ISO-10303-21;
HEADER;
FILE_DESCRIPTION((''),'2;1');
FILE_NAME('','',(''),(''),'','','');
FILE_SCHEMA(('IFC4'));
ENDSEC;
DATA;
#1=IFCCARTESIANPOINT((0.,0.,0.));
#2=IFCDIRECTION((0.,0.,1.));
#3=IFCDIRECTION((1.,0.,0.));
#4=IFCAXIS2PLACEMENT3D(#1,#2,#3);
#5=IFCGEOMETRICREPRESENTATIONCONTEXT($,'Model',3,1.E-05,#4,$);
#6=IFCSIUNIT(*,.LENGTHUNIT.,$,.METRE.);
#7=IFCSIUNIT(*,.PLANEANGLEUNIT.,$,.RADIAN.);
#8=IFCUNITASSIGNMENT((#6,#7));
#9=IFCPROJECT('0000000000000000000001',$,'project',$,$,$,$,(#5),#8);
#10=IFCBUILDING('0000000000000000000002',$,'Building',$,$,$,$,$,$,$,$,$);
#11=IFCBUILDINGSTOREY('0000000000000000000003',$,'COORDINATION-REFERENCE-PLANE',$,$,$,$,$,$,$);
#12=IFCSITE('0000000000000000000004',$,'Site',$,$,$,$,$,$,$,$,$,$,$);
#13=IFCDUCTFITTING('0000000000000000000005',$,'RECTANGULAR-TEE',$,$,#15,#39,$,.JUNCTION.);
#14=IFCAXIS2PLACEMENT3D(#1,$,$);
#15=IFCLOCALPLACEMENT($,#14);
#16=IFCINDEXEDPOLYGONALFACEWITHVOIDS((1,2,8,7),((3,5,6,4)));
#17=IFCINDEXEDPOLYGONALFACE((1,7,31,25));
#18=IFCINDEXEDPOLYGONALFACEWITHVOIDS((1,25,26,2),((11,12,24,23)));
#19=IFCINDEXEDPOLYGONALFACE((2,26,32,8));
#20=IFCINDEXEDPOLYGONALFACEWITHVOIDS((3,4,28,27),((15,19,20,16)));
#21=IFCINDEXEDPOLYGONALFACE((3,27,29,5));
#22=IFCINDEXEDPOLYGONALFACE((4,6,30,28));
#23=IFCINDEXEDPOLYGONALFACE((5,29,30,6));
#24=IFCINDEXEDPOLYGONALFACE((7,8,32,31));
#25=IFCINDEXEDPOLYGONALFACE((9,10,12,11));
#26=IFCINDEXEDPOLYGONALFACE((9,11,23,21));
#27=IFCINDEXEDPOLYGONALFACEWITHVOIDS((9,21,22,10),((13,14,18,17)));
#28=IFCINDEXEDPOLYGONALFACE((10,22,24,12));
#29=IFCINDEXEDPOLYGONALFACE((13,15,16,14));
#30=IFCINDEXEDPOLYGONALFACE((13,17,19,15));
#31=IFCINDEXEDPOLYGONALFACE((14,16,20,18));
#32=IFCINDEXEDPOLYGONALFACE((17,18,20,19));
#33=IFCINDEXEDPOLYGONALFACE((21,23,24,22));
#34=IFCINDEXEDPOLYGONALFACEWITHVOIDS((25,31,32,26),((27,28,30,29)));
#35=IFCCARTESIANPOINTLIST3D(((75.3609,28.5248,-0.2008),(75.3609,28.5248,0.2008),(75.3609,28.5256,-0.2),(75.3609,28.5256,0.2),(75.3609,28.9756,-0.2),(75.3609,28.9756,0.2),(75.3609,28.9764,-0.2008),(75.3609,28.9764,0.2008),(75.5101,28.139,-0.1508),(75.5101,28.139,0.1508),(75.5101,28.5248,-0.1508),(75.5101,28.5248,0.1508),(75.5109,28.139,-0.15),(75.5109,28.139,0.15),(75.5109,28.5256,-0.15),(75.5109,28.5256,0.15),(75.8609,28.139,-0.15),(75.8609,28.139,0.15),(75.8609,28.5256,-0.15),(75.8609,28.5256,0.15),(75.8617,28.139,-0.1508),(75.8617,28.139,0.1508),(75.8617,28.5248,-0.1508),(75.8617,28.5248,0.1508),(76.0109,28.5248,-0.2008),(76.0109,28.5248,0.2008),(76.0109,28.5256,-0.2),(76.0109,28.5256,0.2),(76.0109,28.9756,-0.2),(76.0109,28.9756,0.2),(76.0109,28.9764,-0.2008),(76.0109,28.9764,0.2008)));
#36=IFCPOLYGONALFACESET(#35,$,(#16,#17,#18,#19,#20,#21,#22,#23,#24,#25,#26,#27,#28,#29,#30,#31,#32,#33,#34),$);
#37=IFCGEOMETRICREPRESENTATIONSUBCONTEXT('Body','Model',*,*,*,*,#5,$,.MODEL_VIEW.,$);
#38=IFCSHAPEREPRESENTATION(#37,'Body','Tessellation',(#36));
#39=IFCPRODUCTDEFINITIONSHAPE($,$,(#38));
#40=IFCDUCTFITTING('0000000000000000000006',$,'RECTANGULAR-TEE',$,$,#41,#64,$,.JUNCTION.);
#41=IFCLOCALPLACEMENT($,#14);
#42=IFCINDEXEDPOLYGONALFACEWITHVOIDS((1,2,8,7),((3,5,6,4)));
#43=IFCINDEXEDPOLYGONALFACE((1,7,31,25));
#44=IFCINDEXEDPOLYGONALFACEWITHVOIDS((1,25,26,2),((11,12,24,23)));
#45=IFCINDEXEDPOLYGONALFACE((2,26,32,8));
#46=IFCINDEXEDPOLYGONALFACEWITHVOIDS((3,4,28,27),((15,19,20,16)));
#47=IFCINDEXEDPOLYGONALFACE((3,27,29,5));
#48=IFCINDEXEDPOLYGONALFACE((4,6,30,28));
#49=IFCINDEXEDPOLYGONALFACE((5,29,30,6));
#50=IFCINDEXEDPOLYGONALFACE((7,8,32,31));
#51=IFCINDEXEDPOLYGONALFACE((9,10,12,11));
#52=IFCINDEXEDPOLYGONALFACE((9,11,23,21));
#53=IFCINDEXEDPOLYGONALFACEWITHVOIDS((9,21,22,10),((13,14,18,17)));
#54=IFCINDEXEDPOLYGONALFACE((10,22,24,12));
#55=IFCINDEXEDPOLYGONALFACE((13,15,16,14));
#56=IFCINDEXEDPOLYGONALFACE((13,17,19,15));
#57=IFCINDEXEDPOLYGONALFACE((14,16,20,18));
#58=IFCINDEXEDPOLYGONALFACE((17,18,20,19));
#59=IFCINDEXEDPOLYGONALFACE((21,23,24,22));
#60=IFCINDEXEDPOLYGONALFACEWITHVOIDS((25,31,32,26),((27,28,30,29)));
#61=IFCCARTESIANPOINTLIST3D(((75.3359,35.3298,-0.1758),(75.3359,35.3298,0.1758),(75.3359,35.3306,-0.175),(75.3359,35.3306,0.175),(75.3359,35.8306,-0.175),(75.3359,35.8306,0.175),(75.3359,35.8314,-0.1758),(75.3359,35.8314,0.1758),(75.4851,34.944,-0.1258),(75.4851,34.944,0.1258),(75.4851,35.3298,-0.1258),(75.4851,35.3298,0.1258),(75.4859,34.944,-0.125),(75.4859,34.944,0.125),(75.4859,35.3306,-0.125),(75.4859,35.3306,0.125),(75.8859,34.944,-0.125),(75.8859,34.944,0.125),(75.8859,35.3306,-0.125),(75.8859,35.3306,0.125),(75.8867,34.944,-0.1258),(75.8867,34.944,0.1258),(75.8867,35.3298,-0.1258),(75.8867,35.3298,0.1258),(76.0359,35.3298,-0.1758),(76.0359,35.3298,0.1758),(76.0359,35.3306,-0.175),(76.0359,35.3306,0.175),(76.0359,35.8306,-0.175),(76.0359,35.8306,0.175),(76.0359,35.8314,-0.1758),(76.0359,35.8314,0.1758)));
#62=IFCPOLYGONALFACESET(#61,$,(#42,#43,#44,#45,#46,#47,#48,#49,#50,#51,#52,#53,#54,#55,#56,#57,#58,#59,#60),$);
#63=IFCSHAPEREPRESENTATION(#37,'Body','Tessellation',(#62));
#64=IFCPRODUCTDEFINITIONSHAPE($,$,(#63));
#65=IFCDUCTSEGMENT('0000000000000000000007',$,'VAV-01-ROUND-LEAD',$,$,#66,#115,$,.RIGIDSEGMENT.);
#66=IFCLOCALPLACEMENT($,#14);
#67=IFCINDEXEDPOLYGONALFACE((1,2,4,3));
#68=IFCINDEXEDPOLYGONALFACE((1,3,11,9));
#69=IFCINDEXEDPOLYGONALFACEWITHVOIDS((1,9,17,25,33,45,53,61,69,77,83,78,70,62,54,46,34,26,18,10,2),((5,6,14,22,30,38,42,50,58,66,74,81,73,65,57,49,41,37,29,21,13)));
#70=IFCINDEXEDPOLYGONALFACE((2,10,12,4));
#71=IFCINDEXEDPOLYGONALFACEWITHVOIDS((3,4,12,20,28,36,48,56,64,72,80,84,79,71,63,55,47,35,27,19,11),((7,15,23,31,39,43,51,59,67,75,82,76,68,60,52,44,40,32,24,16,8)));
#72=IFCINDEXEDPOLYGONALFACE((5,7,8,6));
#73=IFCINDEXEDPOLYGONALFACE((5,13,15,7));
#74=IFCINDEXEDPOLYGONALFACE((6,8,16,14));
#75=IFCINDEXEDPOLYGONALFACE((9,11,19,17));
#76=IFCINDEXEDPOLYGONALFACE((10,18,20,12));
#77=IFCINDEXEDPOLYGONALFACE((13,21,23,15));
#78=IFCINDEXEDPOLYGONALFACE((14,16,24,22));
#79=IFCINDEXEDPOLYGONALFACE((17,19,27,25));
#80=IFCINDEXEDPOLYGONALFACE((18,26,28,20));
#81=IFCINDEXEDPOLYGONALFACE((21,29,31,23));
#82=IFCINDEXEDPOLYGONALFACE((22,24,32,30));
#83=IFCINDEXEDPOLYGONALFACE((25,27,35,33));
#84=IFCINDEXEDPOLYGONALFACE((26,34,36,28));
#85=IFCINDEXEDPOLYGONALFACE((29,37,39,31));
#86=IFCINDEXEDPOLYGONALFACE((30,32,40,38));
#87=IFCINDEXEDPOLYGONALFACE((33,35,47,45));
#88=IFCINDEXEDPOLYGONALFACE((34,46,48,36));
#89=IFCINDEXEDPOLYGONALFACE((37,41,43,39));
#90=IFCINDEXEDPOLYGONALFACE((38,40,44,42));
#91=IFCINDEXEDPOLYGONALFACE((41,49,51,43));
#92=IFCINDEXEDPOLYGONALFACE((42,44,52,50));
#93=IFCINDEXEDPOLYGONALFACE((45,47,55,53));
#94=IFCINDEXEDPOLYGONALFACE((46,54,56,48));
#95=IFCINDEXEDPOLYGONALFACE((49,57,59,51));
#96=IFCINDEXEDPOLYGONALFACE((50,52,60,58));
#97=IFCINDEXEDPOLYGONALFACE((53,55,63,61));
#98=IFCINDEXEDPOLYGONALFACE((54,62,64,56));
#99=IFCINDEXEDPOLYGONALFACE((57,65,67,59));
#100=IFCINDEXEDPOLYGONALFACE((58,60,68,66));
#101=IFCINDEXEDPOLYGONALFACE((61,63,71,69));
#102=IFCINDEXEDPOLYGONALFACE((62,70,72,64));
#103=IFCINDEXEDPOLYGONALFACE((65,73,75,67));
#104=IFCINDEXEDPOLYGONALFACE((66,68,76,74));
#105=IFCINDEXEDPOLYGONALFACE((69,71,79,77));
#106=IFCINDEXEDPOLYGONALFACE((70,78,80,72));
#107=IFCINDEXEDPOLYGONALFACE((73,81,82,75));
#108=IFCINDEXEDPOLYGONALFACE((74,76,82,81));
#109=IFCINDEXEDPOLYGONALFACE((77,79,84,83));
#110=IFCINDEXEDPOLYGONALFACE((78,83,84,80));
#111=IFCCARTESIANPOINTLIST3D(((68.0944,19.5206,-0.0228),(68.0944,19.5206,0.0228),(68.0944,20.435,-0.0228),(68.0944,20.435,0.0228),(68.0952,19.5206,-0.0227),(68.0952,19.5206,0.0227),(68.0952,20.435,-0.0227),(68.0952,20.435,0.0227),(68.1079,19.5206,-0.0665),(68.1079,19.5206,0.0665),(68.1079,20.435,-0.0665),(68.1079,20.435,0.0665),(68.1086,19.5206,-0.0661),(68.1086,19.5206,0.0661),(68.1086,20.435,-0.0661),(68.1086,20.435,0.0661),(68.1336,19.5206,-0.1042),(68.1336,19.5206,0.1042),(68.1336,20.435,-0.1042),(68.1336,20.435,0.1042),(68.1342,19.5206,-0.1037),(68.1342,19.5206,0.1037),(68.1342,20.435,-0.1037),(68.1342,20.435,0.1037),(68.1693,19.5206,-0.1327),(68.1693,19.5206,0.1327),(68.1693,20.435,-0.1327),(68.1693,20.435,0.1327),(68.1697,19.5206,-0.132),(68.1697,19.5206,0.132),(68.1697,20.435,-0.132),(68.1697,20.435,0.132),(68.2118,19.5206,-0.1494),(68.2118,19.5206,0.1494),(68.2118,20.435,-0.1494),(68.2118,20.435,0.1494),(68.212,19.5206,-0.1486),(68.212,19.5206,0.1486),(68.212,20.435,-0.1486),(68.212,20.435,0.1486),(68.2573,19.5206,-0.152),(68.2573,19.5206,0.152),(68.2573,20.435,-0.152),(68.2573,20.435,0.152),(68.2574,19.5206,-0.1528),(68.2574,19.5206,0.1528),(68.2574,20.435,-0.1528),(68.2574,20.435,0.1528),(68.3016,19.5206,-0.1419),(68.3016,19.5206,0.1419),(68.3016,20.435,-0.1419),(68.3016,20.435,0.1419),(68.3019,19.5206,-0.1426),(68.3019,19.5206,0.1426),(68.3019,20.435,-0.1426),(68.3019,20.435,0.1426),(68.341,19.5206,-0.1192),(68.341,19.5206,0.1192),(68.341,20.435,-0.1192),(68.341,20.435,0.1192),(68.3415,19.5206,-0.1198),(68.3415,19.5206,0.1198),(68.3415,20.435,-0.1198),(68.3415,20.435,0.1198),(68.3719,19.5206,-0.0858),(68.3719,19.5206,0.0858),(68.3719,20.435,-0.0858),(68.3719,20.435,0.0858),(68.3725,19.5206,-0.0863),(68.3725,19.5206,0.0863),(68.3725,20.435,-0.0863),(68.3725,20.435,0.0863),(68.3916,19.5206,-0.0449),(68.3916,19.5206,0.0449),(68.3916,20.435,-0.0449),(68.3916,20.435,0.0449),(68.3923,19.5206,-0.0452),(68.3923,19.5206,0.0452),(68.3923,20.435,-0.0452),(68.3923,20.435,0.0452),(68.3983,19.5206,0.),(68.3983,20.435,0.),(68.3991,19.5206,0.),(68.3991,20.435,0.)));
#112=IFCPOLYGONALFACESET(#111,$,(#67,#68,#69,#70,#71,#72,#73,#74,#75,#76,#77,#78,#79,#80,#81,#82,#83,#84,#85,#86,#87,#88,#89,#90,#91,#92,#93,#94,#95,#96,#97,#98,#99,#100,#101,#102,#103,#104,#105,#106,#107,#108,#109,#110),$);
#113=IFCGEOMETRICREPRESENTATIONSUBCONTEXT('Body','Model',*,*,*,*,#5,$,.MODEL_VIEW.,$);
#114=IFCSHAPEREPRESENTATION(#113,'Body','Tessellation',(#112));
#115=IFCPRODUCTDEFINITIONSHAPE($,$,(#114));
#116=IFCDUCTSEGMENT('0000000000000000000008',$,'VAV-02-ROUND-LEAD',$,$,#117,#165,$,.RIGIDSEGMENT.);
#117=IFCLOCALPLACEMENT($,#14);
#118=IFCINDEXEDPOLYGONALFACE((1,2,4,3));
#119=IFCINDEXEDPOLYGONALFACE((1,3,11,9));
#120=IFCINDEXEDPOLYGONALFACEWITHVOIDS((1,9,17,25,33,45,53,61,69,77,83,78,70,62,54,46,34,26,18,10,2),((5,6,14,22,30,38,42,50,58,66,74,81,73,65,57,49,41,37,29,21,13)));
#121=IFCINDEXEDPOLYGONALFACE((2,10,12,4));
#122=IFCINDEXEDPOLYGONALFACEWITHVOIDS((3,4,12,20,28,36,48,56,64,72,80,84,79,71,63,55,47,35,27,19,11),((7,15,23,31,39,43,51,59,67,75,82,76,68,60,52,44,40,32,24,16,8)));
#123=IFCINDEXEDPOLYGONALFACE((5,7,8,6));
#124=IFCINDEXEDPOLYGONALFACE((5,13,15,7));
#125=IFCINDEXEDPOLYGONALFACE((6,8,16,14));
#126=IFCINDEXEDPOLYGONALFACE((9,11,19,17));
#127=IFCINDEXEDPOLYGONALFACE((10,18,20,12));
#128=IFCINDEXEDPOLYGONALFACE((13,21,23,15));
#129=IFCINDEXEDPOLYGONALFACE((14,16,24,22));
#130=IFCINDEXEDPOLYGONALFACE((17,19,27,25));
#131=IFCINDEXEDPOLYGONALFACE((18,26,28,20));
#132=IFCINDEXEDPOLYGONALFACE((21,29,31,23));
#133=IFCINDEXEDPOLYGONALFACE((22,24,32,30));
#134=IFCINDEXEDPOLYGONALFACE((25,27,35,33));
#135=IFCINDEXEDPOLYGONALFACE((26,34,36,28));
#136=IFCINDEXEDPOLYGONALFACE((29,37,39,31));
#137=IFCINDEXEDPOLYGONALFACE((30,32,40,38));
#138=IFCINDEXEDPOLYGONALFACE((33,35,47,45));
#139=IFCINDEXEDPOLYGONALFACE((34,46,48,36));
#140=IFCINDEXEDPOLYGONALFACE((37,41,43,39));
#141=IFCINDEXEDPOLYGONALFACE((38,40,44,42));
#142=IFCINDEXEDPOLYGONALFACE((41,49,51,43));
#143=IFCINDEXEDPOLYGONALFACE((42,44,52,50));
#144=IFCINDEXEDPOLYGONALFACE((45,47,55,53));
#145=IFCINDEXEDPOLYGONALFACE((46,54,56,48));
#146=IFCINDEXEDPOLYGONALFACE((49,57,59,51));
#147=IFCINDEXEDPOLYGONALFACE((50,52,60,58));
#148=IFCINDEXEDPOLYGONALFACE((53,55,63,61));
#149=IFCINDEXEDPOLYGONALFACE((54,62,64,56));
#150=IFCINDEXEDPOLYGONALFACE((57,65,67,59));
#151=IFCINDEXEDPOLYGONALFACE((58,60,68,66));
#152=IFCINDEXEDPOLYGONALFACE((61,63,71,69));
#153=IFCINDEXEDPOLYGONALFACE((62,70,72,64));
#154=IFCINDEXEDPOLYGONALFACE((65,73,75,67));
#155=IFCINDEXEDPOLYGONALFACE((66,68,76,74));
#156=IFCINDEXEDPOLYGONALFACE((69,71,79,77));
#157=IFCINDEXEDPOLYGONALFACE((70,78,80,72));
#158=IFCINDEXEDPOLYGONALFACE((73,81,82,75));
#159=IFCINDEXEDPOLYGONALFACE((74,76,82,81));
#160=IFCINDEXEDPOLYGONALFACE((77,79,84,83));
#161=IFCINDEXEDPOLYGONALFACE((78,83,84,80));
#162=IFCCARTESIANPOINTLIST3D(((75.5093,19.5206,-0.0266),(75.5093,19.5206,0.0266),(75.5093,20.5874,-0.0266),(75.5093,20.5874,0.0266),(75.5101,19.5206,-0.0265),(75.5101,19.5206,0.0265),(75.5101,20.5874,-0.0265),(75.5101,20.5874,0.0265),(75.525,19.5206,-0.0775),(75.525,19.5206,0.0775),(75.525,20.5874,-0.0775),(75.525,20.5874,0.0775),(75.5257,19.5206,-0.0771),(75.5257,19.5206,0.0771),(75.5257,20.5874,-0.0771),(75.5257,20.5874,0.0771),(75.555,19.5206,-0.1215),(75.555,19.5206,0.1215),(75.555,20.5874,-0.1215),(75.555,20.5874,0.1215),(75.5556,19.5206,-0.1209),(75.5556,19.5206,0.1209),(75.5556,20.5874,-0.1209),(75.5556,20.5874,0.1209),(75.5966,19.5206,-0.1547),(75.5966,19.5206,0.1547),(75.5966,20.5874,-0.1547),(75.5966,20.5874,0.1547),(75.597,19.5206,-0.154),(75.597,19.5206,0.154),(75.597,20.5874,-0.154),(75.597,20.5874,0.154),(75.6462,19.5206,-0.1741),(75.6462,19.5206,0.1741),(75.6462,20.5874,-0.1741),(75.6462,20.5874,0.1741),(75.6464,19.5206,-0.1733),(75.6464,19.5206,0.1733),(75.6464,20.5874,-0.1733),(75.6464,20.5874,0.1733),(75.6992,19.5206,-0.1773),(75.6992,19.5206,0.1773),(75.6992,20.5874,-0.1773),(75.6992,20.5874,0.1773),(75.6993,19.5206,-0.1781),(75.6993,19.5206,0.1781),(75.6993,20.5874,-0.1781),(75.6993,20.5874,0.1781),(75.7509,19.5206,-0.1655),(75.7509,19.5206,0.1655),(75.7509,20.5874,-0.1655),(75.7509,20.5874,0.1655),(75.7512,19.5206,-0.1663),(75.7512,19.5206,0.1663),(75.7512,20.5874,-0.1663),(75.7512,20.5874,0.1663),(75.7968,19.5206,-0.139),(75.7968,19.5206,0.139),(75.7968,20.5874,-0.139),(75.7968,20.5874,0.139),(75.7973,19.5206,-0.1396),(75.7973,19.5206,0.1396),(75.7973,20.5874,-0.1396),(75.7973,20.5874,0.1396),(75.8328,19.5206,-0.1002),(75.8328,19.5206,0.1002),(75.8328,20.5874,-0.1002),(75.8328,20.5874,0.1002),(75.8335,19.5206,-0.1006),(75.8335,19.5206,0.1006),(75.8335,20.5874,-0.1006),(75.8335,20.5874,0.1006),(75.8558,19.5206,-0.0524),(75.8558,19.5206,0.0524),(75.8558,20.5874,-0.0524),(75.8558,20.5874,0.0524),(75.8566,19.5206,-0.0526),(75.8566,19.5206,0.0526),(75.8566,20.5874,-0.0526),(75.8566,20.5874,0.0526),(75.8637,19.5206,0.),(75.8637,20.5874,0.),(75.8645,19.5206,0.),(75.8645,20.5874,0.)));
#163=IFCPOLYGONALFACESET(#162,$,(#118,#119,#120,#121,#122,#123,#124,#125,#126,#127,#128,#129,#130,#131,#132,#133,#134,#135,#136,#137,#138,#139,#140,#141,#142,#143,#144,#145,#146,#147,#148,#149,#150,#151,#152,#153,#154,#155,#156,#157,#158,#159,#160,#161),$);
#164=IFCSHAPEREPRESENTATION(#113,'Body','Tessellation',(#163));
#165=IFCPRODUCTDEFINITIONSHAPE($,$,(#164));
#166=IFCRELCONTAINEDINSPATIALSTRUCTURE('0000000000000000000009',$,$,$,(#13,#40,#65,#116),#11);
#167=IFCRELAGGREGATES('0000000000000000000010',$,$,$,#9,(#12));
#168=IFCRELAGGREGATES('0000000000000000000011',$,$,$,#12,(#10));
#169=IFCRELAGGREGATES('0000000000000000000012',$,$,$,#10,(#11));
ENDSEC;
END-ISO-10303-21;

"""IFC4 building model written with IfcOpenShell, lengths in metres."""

from ifc_helpers import new_model, si_unit, frame, origin, origin_with_axes, place, context, subcontext, project, spatial, rectangle, hollow_circle, extrude, boolean, element, save


model = new_model("IFC4")

# Units and contexts
model_context = context("Model", 3, precision=1e-05, world=origin_with_axes())
body_context_1 = subcontext(model_context, "Body", "Model", "MODEL_VIEW")
body_context_2 = subcontext(model_context, "Body", "Model", "MODEL_VIEW")
ifc_project = project(units=[si_unit("LENGTHUNIT", "METRE"), si_unit("PLANEANGLEUNIT", "RADIAN")], contexts=[model_context])

# Site, building, storey
site = spatial("IfcSite", under=ifc_project, Name="Site")
building = spatial("IfcBuilding", under=site, Name="Building")
storey = spatial("IfcBuildingStorey", under=building, Name="COORDINATION-REFERENCE-PLANE")

# Duct fittings
duct_fitting_1_placement = place(None, frame((75.6859, 28.7506, 0.0), z_axis=(-1.0, 0.0, 0.0), x_axis=(0.0, -1.0, 0.0)))
solid_1 = boolean("UNION", extrude(rectangle(XDim=0.45, YDim=0.4), frame((0.0, 0.0, -0.325), z_axis=(0.0, 0.0, 1.0), x_axis=(1.0, 0.0, 0.0)), (0.0, 0.0, 1.0), 0.65), extrude(rectangle(XDim=0.35, YDim=0.3), frame((0.0, 0.0, 0.0), z_axis=(1.0, 0.0, 0.0), x_axis=(0.0, 0.0, -1.0)), (0.0, 0.0, 1.0), 0.6116))
element("IfcDuctFitting", 1, at=duct_fitting_1_placement, inside=storey, Name="RECTANGULAR-TEE", PredefinedType="JUNCTION", context=body_context_1, shape_type="CSG", body=[
    boolean("DIFFERENCE", boolean("UNION", extrude(rectangle(XDim=0.4516, YDim=0.4016), frame((0.0, 0.0, -0.325), z_axis=(0.0, 0.0, 1.0), x_axis=(1.0, 0.0, 0.0)), (0.0, 0.0, 1.0), 0.65), extrude(rectangle(XDim=0.3516, YDim=0.3016), frame((0.0, 0.0, 0.0), z_axis=(1.0, 0.0, 0.0), x_axis=(0.0, 0.0, -1.0)), (0.0, 0.0, 1.0), 0.6116)), solid_1),
])
duct_fitting_2_placement = place(None, frame((75.6859, 35.5806, 0.0), z_axis=(-1.0, 0.0, 0.0), x_axis=(0.0, -1.0, 0.0)))
solid_2 = boolean("UNION", extrude(rectangle(XDim=0.5, YDim=0.35), frame((0.0, 0.0, -0.35), z_axis=(0.0, 0.0, 1.0), x_axis=(1.0, 0.0, 0.0)), (0.0, 0.0, 1.0), 0.7), extrude(rectangle(XDim=0.4, YDim=0.25), frame((0.0, 0.0, 0.0), z_axis=(1.0, 0.0, 0.0), x_axis=(0.0, 0.0, -1.0)), (0.0, 0.0, 1.0), 0.6366))
element("IfcDuctFitting", 2, at=duct_fitting_2_placement, inside=storey, Name="RECTANGULAR-TEE", PredefinedType="JUNCTION", context=body_context_1, shape_type="CSG", body=[
    boolean("DIFFERENCE", boolean("UNION", extrude(rectangle(XDim=0.5016, YDim=0.3516), frame((0.0, 0.0, -0.35), z_axis=(0.0, 0.0, 1.0), x_axis=(1.0, 0.0, 0.0)), (0.0, 0.0, 1.0), 0.7), extrude(rectangle(XDim=0.4016, YDim=0.2516), frame((0.0, 0.0, 0.0), z_axis=(1.0, 0.0, 0.0), x_axis=(0.0, 0.0, -1.0)), (0.0, 0.0, 1.0), 0.6366)), solid_2),
])

# Duct segments
duct_segment_1_placement = place(None, frame((68.2459, 20.435, 0.0), z_axis=(0.0, -1.0, 0.0), x_axis=(1.0, 0.0, 0.0)))
element("IfcDuctSegment", 3, at=duct_segment_1_placement, inside=storey, Name="VAV-01-ROUND-LEAD", PredefinedType="RIGIDSEGMENT", context=body_context_2, shape_type="SweptSolid", body=[
    extrude(hollow_circle(Radius=0.1532, WallThickness=0.0008), origin(), (0.0, 0.0, 1.0), 0.9144),
])
for number, where, z_axis, x_axis, name in (
    (4, (75.6859, 20.5874, 0.0), (0.0, -1.0, 0.0), (1.0, 0.0, 0.0), "VAV-02-ROUND-LEAD"),
):
    element("IfcDuctSegment", number, at=place(None, frame(where, z_axis=z_axis, x_axis=x_axis)), inside=storey, Name=name, PredefinedType="RIGIDSEGMENT", context=body_context_2, shape_type="SweptSolid", body=[
        extrude(hollow_circle(Radius=0.1786, WallThickness=0.0008), origin(), (0.0, 0.0, 1.0), 1.0668),
    ])

save(model, "model.ifc")
